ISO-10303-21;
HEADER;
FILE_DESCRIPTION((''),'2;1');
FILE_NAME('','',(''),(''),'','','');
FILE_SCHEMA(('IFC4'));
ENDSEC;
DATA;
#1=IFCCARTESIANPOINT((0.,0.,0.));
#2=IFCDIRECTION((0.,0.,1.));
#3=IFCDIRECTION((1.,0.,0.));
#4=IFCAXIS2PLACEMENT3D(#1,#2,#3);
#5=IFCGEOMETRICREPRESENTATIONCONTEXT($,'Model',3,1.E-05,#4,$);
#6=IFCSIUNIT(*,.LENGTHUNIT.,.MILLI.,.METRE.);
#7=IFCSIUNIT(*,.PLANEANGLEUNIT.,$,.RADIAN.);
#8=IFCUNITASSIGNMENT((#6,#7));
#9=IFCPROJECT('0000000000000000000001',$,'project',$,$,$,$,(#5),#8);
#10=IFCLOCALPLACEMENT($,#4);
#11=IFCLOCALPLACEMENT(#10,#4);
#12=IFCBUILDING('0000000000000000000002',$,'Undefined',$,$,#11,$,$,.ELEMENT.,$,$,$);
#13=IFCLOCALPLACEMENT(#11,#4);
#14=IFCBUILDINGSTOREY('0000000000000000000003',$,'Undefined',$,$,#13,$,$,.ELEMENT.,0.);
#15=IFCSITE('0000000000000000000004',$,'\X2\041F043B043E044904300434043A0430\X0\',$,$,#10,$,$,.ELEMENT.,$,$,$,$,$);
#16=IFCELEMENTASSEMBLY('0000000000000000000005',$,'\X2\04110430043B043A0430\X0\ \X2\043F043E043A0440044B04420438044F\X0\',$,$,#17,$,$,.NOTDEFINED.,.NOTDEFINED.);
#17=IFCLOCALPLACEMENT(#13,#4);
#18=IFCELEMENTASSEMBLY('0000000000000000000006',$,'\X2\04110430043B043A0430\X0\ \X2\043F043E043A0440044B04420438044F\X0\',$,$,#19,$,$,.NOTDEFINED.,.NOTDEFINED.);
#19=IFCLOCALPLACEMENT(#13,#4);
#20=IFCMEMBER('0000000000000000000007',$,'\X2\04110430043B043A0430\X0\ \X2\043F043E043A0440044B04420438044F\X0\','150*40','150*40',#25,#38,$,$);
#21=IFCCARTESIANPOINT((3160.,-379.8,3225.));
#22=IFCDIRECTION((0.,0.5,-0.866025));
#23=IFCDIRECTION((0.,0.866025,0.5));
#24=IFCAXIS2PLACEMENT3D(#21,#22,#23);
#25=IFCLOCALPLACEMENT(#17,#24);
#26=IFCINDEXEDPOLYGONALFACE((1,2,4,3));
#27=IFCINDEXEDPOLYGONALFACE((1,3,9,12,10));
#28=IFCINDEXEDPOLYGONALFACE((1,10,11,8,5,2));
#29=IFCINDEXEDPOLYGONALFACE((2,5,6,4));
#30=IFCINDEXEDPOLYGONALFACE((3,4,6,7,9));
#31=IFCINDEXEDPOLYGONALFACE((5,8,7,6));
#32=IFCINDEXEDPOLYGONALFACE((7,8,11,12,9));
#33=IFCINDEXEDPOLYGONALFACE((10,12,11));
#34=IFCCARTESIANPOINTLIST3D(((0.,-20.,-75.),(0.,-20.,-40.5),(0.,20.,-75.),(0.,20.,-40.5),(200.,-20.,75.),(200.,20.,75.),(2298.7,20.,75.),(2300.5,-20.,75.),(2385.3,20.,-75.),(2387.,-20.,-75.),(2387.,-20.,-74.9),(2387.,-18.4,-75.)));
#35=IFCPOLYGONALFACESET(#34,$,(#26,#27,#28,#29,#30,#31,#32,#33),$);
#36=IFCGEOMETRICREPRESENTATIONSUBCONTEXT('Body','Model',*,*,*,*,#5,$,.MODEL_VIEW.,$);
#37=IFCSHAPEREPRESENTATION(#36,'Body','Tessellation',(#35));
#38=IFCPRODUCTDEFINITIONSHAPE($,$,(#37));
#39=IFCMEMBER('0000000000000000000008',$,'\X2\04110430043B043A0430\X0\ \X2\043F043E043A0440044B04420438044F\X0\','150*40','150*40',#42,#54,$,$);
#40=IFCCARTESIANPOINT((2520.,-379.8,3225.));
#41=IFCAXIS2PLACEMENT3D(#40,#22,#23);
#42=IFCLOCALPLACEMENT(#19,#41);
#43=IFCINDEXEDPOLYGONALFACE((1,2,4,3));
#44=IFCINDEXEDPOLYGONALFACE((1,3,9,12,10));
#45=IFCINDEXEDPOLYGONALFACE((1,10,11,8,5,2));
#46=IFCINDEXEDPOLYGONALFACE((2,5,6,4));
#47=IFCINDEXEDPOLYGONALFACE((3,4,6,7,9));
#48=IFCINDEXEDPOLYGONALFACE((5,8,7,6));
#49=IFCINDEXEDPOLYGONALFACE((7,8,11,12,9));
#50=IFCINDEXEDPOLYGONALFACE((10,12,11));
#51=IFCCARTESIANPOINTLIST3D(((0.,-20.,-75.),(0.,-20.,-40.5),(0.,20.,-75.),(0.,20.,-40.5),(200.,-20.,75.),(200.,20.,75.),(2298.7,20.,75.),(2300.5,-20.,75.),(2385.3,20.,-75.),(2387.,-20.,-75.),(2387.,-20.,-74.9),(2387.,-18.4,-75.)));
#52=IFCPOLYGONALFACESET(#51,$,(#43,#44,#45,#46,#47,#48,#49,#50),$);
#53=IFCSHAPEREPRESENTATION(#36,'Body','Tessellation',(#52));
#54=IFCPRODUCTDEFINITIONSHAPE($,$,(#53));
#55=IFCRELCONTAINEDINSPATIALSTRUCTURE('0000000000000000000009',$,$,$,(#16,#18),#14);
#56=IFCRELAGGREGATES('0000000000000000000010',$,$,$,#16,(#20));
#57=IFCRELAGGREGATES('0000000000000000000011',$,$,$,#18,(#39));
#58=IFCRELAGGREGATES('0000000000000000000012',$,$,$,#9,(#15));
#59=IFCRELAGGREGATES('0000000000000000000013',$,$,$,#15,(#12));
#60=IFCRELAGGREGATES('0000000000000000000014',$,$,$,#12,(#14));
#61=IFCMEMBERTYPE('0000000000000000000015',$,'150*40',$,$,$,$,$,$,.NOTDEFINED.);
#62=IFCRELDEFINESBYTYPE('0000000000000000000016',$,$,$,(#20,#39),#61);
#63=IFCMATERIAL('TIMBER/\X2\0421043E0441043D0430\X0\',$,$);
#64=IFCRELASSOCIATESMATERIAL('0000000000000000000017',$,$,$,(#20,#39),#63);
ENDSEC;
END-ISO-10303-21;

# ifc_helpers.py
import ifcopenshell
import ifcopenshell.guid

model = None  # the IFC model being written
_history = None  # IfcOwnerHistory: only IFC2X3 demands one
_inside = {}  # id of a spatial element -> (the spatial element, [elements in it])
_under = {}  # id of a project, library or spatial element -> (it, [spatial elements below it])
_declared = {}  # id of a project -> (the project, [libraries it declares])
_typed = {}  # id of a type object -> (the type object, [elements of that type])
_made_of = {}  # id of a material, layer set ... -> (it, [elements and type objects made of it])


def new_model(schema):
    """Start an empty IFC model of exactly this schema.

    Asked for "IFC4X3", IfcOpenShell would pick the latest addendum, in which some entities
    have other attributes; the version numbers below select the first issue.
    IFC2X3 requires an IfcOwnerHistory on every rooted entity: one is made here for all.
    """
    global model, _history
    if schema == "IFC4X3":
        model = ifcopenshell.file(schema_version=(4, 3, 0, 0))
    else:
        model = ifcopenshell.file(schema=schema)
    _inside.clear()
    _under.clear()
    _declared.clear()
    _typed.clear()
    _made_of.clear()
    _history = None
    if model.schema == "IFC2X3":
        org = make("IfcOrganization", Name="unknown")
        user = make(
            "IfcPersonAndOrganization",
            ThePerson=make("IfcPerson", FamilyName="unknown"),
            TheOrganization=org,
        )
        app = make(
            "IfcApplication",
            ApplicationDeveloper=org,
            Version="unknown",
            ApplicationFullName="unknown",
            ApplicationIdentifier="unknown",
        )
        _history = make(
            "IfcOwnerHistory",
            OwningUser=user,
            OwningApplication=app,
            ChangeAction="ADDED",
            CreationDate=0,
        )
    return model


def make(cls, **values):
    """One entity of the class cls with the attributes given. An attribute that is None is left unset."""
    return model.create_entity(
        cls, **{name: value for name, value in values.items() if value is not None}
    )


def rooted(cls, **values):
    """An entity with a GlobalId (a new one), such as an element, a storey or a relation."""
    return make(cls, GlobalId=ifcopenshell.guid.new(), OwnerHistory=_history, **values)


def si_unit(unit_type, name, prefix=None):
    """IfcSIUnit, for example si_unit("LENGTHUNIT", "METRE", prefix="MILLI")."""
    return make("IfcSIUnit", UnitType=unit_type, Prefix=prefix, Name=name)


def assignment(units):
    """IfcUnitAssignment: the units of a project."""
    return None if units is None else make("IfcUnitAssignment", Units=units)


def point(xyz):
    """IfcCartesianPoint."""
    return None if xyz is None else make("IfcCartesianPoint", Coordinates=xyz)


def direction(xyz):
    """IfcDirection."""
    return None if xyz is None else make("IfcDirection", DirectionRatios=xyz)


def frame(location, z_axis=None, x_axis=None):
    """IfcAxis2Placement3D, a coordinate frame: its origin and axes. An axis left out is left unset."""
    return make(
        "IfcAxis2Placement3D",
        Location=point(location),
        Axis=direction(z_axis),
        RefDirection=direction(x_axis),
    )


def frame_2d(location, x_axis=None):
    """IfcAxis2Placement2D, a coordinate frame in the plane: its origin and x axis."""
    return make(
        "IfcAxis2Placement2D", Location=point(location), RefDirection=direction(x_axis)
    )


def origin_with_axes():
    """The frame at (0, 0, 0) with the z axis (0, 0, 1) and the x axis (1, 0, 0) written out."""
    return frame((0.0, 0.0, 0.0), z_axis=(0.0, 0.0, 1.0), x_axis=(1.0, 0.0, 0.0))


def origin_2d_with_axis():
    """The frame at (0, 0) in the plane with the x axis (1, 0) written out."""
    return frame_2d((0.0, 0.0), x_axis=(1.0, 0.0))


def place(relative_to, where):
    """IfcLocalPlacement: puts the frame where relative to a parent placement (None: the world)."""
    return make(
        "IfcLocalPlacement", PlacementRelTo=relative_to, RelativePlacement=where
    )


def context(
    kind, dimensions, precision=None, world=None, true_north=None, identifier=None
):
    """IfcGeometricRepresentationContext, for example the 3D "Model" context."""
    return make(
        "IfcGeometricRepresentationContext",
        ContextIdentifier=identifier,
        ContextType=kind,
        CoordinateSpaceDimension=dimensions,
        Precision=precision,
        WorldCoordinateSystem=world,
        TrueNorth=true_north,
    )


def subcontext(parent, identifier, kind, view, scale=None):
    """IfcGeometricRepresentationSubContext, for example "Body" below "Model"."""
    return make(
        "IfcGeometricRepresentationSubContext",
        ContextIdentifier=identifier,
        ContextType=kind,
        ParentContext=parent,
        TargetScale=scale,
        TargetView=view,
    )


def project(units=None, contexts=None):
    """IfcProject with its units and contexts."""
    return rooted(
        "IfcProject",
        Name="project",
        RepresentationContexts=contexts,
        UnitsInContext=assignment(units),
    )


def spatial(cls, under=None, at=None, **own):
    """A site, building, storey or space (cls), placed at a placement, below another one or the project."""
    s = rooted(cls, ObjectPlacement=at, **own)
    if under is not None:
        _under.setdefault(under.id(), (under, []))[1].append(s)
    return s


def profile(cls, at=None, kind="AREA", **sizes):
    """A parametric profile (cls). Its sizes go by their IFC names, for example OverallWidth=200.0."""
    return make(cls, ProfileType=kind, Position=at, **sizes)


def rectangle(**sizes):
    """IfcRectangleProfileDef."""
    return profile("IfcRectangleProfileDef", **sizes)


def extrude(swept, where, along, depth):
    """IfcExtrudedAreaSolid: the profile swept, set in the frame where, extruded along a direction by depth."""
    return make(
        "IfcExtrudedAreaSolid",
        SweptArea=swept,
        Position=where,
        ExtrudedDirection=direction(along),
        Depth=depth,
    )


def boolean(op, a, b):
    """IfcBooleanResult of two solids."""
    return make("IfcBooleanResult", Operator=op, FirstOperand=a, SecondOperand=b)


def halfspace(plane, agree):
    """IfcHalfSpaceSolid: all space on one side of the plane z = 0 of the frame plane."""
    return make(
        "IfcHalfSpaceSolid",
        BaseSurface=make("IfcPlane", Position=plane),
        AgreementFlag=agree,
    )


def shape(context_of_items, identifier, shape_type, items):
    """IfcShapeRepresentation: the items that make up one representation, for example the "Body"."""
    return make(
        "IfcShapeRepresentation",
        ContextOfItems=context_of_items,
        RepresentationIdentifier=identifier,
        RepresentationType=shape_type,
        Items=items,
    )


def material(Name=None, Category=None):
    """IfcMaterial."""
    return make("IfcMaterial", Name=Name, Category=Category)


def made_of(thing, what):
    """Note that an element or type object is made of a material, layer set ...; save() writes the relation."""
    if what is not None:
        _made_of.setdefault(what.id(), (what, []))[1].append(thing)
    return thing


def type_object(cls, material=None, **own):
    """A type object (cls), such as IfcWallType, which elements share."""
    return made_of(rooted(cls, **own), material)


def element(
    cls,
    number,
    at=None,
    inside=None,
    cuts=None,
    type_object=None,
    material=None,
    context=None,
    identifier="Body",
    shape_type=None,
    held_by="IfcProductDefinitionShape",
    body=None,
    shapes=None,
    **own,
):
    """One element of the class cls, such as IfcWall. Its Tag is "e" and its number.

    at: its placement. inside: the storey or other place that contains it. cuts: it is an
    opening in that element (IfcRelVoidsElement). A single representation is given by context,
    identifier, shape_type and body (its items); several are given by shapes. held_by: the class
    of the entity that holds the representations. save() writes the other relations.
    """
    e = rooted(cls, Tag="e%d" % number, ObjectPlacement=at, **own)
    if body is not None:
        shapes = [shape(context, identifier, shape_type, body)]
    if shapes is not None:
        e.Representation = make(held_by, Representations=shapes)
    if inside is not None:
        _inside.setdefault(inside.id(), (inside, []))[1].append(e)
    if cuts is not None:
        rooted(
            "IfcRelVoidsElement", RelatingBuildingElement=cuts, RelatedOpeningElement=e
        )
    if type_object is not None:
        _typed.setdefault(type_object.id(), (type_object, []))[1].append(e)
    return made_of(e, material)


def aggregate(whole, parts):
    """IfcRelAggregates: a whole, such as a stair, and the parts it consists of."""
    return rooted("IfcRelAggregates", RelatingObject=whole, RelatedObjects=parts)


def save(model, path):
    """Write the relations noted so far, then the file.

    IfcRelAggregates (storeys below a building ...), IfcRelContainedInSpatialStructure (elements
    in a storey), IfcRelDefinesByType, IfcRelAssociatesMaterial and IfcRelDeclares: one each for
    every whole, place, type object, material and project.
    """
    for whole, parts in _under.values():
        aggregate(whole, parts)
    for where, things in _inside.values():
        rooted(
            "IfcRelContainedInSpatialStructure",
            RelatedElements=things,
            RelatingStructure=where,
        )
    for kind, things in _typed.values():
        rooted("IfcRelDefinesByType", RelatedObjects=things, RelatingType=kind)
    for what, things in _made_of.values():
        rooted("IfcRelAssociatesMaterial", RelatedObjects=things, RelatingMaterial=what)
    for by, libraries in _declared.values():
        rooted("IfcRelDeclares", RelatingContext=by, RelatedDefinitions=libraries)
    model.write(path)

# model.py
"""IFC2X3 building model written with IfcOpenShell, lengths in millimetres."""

from ifc_helpers import new_model, si_unit, frame, origin_with_axes, origin_2d_with_axis, place, context, subcontext, project, spatial, rectangle, extrude, boolean, halfspace, material, type_object, element, aggregate, save


model = new_model("IFC2X3")

# Units and contexts
model_context = context("Model", 3, precision=1e-05, world=origin_with_axes())
body_context = subcontext(model_context, "Body", "Model", "MODEL_VIEW")
ifc_project = project(units=[si_unit("LENGTHUNIT", "METRE", prefix="MILLI"), si_unit("PLANEANGLEUNIT", "RADIAN")], contexts=[model_context])

# Site, building, storey
site_placement = place(None, origin_with_axes())
site = spatial("IfcSite", under=ifc_project, at=site_placement, Name="Площадка", CompositionType="ELEMENT")
building_placement = place(site_placement, origin_with_axes())
building = spatial("IfcBuilding", under=site, at=building_placement, Name="Undefined", CompositionType="ELEMENT")
storey_placement = place(building_placement, origin_with_axes())
storey = spatial("IfcBuildingStorey", under=building, at=storey_placement, Name="Undefined", CompositionType="ELEMENT", Elevation=0.0)

# Shared definitions
ifc_material_1 = material(Name="TIMBER/Сосна")

# Element assemblies
assembly_1_placement = place(storey_placement, origin_with_axes())
assembly_1 = element("IfcElementAssembly", 1, at=assembly_1_placement, inside=storey, Name="Балка покрытия", AssemblyPlace="NOTDEFINED", PredefinedType="NOTDEFINED")
assembly_2_placement = place(storey_placement, origin_with_axes())
assembly_2 = element("IfcElementAssembly", 2, at=assembly_2_placement, inside=storey, Name="Балка покрытия", AssemblyPlace="NOTDEFINED", PredefinedType="NOTDEFINED")

# Members
member_type_1 = type_object("IfcMemberType", Name="150*40", PredefinedType="NOTDEFINED")
member_1_placement = place(assembly_1_placement, frame((3160.0, -379.8, 3225.0), z_axis=(0.0, 0.5, -0.866025), x_axis=(0.0, 0.866025, 0.5)))
member_1 = element("IfcMember", 3, at=member_1_placement, type_object=member_type_1, material=ifc_material_1, Name="Балка покрытия", Description="150*40", ObjectType="150*40", context=body_context, shape_type="CSG", body=[
    boolean("DIFFERENCE", boolean("DIFFERENCE", extrude(rectangle(XDim=40.0, YDim=150.0, at=origin_2d_with_axis()), frame((2387.0, 0.0, 0.0), z_axis=(-1.0, 0.0, 0.0), x_axis=(0.0, -1.0, 0.0)), (0.0, 0.0, 1.0), 2387.0), extrude(rectangle(XDim=40.0, YDim=150.0, at=origin_2d_with_axis()), frame((3513.2, 0.0, 2074.5), z_axis=(-0.866025, 0.0, -0.5), x_axis=(0.0, -1.0, 0.0)), (0.0, 0.0, 1.0), 4100.0)), halfspace(frame((2298.7, 20.0, 75.0), z_axis=(0.86539, 0.038305, 0.499633), x_axis=(0.5, 0.0, -0.866025)), False)),
])
aggregate(assembly_1, [member_1])
member_2_placement = place(assembly_2_placement, frame((2520.0, -379.8, 3225.0), z_axis=(0.0, 0.5, -0.866025), x_axis=(0.0, 0.866025, 0.5)))
member_2 = element("IfcMember", 4, at=member_2_placement, type_object=member_type_1, material=ifc_material_1, Name="Балка покрытия", Description="150*40", ObjectType="150*40", context=body_context, shape_type="CSG", body=[
    boolean("DIFFERENCE", boolean("DIFFERENCE", extrude(rectangle(XDim=40.0, YDim=150.0, at=origin_2d_with_axis()), frame((2387.0, 0.0, 0.0), z_axis=(-1.0, 0.0, 0.0), x_axis=(0.0, -1.0, 0.0)), (0.0, 0.0, 1.0), 2387.0), extrude(rectangle(XDim=40.0, YDim=150.0, at=origin_2d_with_axis()), frame((3513.2, 0.0, 2074.5), z_axis=(-0.866025, 0.0, -0.5), x_axis=(0.0, -1.0, 0.0)), (0.0, 0.0, 1.0), 4100.0)), halfspace(frame((2298.7, 20.0, 75.0), z_axis=(0.86539, 0.038305, 0.499633), x_axis=(0.5, 0.0, -0.866025)), False)),
])
aggregate(assembly_2, [member_2])

save(model, "model.ifc")
